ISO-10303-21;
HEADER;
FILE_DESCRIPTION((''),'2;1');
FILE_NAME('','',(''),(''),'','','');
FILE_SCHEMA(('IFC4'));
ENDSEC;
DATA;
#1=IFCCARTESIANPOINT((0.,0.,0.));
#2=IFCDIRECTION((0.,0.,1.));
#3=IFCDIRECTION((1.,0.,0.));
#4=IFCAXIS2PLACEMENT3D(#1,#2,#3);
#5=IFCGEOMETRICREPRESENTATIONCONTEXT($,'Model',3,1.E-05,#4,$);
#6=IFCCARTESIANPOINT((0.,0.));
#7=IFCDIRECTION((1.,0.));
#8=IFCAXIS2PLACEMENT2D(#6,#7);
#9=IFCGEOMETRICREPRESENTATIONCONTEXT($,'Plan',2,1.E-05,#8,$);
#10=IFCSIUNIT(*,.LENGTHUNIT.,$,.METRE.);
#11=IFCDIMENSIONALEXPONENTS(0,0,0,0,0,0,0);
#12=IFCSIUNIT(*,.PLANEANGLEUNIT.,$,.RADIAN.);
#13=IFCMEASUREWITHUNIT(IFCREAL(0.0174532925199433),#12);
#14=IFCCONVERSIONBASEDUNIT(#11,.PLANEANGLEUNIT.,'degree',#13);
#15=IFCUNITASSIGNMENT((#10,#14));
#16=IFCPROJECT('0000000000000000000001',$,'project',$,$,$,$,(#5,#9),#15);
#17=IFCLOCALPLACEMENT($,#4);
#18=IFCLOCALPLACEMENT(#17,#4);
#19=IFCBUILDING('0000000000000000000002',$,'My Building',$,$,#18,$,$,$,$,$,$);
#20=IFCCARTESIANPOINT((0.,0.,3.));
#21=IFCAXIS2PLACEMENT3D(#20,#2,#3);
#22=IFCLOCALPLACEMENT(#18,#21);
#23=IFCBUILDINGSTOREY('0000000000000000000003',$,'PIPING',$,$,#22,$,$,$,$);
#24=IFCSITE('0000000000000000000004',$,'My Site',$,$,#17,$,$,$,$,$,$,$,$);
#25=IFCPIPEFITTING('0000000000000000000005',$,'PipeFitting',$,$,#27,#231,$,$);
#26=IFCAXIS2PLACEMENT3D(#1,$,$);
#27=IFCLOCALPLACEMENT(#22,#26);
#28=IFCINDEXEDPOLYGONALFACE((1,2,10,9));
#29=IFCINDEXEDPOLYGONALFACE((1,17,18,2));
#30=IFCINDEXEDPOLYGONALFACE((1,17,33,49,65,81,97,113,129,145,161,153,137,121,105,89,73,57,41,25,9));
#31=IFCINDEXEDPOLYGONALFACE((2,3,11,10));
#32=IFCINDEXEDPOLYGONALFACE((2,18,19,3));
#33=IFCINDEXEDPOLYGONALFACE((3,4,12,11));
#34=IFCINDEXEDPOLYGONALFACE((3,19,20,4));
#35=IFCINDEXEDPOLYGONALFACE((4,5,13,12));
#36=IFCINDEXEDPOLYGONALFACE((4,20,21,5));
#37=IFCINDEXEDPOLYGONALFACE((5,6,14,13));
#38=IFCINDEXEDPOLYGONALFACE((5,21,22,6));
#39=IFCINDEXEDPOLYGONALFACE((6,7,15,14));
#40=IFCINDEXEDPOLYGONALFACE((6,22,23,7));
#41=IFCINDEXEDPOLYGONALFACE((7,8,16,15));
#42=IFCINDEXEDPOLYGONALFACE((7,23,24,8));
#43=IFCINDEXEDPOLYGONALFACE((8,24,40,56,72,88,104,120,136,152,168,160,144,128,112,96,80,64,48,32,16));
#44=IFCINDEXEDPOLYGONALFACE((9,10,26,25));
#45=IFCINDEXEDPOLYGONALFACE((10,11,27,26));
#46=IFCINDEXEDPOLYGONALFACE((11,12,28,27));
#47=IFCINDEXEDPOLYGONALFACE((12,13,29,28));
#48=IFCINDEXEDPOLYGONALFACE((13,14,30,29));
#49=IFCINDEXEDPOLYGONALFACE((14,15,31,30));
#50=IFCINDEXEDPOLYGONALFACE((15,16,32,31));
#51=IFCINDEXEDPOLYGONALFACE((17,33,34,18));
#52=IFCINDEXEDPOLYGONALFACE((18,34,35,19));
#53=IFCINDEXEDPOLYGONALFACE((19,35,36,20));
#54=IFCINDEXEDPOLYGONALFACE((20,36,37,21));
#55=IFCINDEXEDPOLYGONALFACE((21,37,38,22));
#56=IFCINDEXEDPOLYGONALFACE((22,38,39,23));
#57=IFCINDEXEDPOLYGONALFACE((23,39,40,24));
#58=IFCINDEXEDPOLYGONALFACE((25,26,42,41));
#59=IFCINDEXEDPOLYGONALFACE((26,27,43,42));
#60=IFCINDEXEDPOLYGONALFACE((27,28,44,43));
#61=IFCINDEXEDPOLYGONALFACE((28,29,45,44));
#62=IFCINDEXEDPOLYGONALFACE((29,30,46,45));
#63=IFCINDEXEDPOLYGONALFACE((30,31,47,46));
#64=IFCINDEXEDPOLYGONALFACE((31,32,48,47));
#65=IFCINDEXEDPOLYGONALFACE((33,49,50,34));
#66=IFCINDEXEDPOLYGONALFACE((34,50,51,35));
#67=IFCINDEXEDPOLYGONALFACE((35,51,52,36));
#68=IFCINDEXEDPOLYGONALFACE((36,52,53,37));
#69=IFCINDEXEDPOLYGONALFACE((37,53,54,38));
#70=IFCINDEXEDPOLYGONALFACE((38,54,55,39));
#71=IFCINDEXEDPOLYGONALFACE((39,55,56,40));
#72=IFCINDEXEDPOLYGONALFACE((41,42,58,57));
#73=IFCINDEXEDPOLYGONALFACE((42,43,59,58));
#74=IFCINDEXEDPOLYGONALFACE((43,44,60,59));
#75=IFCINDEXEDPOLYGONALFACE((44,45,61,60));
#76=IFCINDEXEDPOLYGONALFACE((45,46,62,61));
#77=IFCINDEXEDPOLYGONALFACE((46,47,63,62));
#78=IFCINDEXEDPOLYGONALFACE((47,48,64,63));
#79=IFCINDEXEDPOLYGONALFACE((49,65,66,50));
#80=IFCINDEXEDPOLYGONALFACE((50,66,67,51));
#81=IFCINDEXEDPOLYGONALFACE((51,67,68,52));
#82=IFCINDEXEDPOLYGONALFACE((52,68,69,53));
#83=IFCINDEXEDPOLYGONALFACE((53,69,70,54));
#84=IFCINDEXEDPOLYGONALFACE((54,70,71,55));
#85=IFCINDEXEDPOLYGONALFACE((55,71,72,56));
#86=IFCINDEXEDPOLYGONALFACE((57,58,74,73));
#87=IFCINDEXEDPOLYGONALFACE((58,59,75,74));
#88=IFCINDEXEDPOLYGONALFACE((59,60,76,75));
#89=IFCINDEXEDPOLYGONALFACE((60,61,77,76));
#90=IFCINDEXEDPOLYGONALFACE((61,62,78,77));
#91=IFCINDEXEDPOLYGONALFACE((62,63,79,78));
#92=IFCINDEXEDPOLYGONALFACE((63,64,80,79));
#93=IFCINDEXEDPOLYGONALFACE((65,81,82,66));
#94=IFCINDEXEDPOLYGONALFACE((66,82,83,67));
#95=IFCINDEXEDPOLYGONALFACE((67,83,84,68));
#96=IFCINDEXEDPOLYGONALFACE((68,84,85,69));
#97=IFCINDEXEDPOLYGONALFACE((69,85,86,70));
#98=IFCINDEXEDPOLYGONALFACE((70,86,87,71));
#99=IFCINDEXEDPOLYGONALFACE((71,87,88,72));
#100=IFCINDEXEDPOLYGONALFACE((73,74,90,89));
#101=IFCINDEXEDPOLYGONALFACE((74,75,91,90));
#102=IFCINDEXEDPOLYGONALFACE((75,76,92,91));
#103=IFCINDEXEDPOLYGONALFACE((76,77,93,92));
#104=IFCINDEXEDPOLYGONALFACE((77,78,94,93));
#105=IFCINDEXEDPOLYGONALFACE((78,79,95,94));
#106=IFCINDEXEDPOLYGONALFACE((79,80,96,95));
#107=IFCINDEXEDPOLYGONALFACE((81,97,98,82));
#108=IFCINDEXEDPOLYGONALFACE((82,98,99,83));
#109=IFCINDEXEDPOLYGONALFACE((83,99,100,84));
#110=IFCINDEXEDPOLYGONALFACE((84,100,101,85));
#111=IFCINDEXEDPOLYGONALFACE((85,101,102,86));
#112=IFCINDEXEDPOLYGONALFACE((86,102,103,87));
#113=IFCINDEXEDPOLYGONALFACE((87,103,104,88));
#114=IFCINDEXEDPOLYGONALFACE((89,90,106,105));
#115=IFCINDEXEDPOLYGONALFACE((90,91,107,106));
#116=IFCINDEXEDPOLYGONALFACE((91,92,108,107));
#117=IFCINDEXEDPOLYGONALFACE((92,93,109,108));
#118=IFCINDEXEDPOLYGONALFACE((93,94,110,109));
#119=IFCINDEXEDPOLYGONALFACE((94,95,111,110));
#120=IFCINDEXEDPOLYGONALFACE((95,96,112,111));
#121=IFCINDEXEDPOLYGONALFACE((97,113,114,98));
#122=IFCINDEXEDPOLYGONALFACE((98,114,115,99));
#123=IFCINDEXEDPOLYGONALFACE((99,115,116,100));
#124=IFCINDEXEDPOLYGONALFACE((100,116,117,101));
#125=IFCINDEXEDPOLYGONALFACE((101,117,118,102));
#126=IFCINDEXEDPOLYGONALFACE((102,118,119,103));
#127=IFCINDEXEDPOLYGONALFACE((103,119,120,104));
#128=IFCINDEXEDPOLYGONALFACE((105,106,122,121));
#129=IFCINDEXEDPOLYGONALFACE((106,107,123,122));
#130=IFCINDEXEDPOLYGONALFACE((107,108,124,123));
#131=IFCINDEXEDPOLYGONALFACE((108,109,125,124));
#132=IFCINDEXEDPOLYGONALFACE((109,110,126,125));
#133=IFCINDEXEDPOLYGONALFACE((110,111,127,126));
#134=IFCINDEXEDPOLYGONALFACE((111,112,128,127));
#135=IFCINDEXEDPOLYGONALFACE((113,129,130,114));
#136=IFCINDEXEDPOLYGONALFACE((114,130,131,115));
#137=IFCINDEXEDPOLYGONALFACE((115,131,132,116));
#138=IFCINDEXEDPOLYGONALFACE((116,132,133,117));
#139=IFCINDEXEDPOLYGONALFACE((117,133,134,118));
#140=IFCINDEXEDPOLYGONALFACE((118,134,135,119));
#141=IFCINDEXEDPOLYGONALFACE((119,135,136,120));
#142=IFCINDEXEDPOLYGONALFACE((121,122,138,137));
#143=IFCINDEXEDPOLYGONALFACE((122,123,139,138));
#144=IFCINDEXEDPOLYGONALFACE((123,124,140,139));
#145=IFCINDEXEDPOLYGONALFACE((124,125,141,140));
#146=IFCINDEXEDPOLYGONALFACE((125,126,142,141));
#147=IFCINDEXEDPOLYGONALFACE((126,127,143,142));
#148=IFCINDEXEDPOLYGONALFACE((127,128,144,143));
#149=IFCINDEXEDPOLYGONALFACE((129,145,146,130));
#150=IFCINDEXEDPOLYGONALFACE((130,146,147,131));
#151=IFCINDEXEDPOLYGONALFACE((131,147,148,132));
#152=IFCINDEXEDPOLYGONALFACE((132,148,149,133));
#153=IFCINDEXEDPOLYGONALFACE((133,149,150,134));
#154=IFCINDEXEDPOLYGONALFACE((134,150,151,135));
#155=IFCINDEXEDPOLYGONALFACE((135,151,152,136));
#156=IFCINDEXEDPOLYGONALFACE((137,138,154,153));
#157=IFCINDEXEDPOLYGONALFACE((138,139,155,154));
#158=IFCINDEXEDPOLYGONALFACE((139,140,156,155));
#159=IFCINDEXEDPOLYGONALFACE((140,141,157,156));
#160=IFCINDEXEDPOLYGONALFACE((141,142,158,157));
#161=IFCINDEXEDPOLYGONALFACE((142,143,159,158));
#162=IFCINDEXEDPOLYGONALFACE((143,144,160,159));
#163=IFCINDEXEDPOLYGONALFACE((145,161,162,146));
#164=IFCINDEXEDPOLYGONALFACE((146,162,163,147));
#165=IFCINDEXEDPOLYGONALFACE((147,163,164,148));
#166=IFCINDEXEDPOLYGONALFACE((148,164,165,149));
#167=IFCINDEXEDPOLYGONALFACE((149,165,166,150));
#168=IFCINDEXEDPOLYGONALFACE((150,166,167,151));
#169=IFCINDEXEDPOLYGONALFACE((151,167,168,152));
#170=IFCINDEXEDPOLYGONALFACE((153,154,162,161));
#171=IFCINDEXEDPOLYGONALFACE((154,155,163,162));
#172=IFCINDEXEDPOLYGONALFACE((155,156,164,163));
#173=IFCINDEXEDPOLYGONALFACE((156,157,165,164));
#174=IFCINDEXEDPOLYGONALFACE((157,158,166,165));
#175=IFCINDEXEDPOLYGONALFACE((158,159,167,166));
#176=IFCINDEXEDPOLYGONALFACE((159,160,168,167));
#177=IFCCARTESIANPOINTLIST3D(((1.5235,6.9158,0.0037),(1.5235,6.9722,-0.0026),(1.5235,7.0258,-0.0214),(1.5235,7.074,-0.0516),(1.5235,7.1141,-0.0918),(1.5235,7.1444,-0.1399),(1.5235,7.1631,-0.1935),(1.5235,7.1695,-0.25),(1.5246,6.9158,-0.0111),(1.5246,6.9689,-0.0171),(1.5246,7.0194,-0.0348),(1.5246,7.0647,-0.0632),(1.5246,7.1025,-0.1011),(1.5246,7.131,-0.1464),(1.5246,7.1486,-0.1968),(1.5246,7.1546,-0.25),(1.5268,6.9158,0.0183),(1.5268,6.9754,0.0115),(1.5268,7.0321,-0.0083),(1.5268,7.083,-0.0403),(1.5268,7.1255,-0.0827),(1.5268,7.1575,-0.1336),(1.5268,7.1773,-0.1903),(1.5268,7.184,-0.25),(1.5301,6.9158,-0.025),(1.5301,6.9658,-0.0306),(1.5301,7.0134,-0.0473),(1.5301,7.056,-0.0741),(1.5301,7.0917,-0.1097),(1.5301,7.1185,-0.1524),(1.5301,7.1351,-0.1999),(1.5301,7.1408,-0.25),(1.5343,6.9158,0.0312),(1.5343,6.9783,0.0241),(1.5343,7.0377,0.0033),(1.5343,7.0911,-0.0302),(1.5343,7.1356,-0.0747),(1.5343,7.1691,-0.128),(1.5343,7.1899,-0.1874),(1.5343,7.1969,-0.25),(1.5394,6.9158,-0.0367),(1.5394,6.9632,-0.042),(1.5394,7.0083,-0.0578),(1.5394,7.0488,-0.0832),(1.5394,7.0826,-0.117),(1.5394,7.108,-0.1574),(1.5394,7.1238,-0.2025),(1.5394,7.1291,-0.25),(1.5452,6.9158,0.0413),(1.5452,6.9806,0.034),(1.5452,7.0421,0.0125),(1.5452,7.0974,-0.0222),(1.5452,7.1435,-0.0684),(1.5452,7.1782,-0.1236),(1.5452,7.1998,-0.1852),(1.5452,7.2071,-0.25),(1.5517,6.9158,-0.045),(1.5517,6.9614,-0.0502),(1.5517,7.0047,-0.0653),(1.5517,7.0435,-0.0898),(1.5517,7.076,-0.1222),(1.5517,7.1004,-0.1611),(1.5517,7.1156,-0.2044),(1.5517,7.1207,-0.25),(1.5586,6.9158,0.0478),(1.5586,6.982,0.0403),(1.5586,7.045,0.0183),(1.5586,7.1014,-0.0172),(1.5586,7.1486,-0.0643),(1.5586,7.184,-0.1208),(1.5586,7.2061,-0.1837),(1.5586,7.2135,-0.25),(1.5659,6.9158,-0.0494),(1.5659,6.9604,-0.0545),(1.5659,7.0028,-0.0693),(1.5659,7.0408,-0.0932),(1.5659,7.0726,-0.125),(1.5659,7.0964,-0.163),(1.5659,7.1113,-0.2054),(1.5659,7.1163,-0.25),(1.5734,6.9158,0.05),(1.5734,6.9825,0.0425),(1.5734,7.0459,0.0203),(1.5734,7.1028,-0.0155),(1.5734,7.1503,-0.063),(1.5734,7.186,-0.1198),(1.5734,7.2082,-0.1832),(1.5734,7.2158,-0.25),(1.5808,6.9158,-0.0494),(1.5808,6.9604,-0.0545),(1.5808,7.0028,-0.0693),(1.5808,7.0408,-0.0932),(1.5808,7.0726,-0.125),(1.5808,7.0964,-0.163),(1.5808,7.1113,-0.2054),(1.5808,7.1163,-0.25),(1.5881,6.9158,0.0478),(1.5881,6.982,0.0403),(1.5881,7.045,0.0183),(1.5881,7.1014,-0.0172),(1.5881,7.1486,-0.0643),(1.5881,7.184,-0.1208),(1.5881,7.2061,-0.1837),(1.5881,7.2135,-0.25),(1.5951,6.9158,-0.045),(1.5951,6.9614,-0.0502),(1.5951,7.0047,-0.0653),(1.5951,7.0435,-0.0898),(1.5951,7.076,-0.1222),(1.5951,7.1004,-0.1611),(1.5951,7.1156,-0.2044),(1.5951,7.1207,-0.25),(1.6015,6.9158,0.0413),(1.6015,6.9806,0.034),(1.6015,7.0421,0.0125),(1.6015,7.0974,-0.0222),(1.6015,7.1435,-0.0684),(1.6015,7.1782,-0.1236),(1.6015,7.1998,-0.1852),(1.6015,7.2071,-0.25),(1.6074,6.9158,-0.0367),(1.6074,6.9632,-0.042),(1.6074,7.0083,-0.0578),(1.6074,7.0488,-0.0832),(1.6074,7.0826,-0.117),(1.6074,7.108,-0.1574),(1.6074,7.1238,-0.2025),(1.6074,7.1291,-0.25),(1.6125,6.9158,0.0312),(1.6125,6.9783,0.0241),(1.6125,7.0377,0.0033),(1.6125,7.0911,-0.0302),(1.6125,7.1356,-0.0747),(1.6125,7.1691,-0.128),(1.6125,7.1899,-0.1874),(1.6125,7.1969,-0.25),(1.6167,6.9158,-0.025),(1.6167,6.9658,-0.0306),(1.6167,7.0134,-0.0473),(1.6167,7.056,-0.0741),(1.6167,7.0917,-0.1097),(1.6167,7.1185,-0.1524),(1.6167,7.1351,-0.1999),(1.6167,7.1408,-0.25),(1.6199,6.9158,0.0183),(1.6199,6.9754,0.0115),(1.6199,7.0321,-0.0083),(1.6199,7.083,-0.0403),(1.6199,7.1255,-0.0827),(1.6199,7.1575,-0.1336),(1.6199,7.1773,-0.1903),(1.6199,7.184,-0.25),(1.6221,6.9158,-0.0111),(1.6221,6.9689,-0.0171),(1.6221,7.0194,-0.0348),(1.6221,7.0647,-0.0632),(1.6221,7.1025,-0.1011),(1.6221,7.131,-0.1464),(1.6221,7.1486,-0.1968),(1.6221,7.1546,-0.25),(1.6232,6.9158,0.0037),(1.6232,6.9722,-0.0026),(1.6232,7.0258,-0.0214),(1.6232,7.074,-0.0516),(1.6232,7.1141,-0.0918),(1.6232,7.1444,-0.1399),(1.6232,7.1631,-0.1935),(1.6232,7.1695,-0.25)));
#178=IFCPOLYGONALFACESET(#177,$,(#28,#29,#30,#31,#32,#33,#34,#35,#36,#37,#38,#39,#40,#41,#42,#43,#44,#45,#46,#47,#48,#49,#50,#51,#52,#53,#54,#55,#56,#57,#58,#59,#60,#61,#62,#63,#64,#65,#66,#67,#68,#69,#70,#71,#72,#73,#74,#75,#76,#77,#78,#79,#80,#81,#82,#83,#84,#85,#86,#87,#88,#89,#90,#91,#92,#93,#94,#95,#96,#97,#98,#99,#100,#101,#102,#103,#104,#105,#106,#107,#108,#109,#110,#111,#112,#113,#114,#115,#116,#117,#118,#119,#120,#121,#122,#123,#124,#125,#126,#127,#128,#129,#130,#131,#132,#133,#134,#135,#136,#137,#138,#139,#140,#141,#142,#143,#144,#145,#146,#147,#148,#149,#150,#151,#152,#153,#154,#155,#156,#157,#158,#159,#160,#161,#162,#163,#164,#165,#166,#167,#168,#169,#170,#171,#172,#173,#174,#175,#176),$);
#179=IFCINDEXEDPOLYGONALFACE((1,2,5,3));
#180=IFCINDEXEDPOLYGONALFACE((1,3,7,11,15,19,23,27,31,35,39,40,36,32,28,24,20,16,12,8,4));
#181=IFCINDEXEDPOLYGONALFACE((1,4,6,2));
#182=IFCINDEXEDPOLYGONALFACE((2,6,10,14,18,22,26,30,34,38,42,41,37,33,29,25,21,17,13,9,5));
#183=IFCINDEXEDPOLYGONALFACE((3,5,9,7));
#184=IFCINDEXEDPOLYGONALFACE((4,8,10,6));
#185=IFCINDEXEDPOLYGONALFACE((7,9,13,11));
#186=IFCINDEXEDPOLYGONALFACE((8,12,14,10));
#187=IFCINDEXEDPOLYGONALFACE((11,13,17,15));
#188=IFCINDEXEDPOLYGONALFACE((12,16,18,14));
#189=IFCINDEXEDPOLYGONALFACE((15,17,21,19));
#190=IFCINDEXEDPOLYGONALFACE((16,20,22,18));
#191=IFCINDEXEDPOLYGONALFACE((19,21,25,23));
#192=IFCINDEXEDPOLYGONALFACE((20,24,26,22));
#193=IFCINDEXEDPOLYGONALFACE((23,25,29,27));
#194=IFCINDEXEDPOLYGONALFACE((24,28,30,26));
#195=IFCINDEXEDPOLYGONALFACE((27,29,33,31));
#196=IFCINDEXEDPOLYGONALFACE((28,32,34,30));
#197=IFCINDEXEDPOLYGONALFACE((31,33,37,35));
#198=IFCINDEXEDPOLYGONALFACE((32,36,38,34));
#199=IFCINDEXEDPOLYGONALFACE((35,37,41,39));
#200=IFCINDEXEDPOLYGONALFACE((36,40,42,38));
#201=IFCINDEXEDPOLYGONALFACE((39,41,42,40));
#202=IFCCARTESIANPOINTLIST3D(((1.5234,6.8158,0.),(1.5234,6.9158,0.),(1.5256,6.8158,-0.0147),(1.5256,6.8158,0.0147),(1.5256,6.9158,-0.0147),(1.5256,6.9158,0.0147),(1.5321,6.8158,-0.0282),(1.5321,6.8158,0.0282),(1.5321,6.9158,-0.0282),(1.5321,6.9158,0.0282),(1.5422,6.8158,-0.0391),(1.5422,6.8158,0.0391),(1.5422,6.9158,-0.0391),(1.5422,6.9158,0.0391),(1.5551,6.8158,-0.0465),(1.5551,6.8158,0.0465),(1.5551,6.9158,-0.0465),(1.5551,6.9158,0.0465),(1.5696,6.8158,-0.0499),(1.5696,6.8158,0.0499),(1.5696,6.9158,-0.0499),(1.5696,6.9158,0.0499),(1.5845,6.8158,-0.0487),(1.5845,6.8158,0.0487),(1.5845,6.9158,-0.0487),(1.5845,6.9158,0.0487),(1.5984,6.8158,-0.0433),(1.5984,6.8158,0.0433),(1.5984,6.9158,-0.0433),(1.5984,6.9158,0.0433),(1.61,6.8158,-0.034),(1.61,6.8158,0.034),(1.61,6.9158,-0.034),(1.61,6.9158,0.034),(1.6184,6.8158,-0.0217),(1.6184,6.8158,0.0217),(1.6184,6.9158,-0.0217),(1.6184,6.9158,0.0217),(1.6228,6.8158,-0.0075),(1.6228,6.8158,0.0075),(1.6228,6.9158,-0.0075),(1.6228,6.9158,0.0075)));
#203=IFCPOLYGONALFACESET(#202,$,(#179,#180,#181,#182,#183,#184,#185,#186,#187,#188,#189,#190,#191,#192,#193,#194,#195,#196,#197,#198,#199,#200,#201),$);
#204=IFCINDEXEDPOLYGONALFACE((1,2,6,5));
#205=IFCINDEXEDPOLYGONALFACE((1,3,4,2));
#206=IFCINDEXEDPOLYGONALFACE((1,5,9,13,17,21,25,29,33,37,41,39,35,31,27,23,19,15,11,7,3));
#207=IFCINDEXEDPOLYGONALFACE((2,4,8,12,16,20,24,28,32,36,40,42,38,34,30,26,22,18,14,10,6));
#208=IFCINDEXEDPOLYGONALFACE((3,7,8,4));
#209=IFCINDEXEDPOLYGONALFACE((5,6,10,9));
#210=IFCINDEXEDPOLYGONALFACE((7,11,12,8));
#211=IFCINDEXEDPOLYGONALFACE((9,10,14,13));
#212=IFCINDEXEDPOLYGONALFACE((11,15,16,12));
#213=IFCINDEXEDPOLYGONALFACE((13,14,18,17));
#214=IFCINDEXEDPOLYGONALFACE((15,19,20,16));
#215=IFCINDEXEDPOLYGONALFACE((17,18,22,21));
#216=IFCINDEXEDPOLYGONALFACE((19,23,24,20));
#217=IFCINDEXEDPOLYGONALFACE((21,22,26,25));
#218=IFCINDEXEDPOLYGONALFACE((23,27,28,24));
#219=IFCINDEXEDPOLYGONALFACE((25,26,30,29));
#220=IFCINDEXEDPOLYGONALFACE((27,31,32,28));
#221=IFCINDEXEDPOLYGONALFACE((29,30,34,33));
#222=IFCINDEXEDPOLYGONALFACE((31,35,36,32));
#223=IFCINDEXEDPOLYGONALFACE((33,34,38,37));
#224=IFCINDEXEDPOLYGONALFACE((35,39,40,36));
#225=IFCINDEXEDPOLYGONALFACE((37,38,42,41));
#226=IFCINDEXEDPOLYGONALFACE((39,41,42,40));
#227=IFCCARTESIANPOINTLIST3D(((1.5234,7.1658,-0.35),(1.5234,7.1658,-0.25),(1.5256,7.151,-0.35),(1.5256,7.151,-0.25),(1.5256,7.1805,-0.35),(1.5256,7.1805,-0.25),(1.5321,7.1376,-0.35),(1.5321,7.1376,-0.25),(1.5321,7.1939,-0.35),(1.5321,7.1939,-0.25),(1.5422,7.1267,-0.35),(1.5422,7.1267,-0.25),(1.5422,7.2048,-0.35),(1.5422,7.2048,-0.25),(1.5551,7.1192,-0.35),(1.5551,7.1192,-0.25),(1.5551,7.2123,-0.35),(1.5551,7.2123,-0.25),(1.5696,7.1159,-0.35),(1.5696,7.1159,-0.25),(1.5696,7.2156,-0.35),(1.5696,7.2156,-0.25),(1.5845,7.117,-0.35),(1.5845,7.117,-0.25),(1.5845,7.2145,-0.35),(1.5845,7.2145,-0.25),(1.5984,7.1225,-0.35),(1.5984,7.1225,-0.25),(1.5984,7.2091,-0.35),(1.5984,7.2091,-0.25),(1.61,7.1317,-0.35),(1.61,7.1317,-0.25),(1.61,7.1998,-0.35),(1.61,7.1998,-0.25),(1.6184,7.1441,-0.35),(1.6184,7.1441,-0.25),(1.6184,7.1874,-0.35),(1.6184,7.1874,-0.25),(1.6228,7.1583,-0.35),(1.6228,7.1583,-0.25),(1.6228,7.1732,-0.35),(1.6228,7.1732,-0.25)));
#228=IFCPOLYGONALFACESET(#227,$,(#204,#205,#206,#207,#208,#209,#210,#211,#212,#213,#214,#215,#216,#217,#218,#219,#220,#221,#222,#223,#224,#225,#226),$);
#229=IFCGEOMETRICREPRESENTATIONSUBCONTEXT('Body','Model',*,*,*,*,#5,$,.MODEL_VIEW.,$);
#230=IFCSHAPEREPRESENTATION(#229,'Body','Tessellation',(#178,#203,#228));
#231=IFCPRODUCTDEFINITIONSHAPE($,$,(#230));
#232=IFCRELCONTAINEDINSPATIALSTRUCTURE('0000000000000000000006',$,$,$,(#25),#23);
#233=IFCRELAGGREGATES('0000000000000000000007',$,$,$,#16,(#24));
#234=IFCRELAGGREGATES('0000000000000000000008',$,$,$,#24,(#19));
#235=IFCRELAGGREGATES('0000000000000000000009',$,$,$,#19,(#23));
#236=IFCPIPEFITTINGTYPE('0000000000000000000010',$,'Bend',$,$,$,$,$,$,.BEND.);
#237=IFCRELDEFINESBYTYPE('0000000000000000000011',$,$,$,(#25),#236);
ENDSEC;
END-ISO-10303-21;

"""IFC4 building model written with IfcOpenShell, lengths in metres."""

from ifc_helpers import new_model, entity, si_unit, converted_unit, frame, origin_with_axes, origin_2d_with_axis, place, context, subcontext, project, spatial, line, indexed_curve, circle, outline, extrude, source, transform, mapped, type_object, type_shapes, element, save


model = new_model("IFC4")

# Units and contexts
model_context = context("Model", 3, precision=1e-05, world=origin_with_axes())
plan_context = context("Plan", 2, precision=1e-05, world=origin_2d_with_axis())
body_context = subcontext(model_context, "Body", "Model", "MODEL_VIEW")
ifc_project = project(units=[si_unit("LENGTHUNIT", "METRE"), converted_unit("PLANEANGLEUNIT", "degree", entity("IfcReal", 0.0174532925199433), si_unit("PLANEANGLEUNIT", "RADIAN"), dimensions=[0, 0, 0, 0, 0, 0, 0])], contexts=[model_context, plan_context])

# Site, building, storey
site_placement = place(None, origin_with_axes())
site = spatial("IfcSite", under=ifc_project, at=site_placement, Name="My Site")
building_placement = place(site_placement, origin_with_axes())
building = spatial("IfcBuilding", under=site, at=building_placement, Name="My Building")
storey_placement = place(building_placement, frame((0.0, 0.0, 3.0), z_axis=(0.0, 0.0, 1.0), x_axis=(1.0, 0.0, 0.0)))
storey = spatial("IfcBuildingStorey", under=building, at=storey_placement, Name="PIPING")

# Pipe fitting, opening
pipe_fitting_type = type_object("IfcPipeFittingType", Name="Bend", PredefinedType="BEND")
shared_shape = source(origin_with_axes(), body_context, "Body", "SolidModel", [
    entity("IfcSweptDiskSolid", entity("IfcIndexedPolyCurve", entity("IfcCartesianPointList3D", [[0.0, 0.0, 0.1], [0.0, -0.0732, 0.2768], [0.0, -0.25, 0.35]]), [entity("IfcArcIndex", [1, 2, 3])]), 0.05),
    extrude(circle(Radius=0.05), origin_with_axes(), (0.0, 0.0, 1.0), 0.1),
    extrude(circle(Radius=0.05), frame((0.0, -0.25, 0.35), z_axis=(0.0, -1.0, 0.0), x_axis=(1.0, 0.0, 0.0)), (0.0, 0.0, 1.0), 0.1),
])
type_shapes(pipe_fitting_type, [shared_shape])
pipe_fitting_1_placement = place(storey_placement, frame((1.5734, 6.8158, 0.0), z_axis=(0.0, 1.0, 0.0), x_axis=(-1.0, 0.0, 0.0)))
pipe_fitting_1 = element("IfcPipeFitting", 1, at=pipe_fitting_1_placement, inside=storey, type_object=pipe_fitting_type, Name="PipeFitting", context=body_context, shape_type="MappedRepresentation", body=[
    mapped(shared_shape, transform((0.0, 0.0, 0.0), x_axis=(1.0, 0.0, 0.0), y_axis=(0.0, 1.0, 0.0), z_axis=(0.0, 0.0, 1.0), scale=1.0)),
])
opening_1_placement = place(pipe_fitting_1_placement, frame((1.5734, -3.0, -6.8158), z_axis=(0.0, 1.0, 0.0), x_axis=(-1.0, 0.0, 0.0)))
element("IfcOpeningElement", 2, at=opening_1_placement, cuts=pipe_fitting_1, PredefinedType="OPENING", context=body_context, shape_type="SweptSolid", body=[
    extrude(outline(indexed_curve([(0.0, 0.0), (0.5, 0.0), (0.5, 0.5), (0.0, 0.5)], segments=[line(1, 2, 3, 4, 1)])), origin_with_axes(), (0.0, 0.0, 1.0), 0.5),
])

save(model, "model.ifc")
